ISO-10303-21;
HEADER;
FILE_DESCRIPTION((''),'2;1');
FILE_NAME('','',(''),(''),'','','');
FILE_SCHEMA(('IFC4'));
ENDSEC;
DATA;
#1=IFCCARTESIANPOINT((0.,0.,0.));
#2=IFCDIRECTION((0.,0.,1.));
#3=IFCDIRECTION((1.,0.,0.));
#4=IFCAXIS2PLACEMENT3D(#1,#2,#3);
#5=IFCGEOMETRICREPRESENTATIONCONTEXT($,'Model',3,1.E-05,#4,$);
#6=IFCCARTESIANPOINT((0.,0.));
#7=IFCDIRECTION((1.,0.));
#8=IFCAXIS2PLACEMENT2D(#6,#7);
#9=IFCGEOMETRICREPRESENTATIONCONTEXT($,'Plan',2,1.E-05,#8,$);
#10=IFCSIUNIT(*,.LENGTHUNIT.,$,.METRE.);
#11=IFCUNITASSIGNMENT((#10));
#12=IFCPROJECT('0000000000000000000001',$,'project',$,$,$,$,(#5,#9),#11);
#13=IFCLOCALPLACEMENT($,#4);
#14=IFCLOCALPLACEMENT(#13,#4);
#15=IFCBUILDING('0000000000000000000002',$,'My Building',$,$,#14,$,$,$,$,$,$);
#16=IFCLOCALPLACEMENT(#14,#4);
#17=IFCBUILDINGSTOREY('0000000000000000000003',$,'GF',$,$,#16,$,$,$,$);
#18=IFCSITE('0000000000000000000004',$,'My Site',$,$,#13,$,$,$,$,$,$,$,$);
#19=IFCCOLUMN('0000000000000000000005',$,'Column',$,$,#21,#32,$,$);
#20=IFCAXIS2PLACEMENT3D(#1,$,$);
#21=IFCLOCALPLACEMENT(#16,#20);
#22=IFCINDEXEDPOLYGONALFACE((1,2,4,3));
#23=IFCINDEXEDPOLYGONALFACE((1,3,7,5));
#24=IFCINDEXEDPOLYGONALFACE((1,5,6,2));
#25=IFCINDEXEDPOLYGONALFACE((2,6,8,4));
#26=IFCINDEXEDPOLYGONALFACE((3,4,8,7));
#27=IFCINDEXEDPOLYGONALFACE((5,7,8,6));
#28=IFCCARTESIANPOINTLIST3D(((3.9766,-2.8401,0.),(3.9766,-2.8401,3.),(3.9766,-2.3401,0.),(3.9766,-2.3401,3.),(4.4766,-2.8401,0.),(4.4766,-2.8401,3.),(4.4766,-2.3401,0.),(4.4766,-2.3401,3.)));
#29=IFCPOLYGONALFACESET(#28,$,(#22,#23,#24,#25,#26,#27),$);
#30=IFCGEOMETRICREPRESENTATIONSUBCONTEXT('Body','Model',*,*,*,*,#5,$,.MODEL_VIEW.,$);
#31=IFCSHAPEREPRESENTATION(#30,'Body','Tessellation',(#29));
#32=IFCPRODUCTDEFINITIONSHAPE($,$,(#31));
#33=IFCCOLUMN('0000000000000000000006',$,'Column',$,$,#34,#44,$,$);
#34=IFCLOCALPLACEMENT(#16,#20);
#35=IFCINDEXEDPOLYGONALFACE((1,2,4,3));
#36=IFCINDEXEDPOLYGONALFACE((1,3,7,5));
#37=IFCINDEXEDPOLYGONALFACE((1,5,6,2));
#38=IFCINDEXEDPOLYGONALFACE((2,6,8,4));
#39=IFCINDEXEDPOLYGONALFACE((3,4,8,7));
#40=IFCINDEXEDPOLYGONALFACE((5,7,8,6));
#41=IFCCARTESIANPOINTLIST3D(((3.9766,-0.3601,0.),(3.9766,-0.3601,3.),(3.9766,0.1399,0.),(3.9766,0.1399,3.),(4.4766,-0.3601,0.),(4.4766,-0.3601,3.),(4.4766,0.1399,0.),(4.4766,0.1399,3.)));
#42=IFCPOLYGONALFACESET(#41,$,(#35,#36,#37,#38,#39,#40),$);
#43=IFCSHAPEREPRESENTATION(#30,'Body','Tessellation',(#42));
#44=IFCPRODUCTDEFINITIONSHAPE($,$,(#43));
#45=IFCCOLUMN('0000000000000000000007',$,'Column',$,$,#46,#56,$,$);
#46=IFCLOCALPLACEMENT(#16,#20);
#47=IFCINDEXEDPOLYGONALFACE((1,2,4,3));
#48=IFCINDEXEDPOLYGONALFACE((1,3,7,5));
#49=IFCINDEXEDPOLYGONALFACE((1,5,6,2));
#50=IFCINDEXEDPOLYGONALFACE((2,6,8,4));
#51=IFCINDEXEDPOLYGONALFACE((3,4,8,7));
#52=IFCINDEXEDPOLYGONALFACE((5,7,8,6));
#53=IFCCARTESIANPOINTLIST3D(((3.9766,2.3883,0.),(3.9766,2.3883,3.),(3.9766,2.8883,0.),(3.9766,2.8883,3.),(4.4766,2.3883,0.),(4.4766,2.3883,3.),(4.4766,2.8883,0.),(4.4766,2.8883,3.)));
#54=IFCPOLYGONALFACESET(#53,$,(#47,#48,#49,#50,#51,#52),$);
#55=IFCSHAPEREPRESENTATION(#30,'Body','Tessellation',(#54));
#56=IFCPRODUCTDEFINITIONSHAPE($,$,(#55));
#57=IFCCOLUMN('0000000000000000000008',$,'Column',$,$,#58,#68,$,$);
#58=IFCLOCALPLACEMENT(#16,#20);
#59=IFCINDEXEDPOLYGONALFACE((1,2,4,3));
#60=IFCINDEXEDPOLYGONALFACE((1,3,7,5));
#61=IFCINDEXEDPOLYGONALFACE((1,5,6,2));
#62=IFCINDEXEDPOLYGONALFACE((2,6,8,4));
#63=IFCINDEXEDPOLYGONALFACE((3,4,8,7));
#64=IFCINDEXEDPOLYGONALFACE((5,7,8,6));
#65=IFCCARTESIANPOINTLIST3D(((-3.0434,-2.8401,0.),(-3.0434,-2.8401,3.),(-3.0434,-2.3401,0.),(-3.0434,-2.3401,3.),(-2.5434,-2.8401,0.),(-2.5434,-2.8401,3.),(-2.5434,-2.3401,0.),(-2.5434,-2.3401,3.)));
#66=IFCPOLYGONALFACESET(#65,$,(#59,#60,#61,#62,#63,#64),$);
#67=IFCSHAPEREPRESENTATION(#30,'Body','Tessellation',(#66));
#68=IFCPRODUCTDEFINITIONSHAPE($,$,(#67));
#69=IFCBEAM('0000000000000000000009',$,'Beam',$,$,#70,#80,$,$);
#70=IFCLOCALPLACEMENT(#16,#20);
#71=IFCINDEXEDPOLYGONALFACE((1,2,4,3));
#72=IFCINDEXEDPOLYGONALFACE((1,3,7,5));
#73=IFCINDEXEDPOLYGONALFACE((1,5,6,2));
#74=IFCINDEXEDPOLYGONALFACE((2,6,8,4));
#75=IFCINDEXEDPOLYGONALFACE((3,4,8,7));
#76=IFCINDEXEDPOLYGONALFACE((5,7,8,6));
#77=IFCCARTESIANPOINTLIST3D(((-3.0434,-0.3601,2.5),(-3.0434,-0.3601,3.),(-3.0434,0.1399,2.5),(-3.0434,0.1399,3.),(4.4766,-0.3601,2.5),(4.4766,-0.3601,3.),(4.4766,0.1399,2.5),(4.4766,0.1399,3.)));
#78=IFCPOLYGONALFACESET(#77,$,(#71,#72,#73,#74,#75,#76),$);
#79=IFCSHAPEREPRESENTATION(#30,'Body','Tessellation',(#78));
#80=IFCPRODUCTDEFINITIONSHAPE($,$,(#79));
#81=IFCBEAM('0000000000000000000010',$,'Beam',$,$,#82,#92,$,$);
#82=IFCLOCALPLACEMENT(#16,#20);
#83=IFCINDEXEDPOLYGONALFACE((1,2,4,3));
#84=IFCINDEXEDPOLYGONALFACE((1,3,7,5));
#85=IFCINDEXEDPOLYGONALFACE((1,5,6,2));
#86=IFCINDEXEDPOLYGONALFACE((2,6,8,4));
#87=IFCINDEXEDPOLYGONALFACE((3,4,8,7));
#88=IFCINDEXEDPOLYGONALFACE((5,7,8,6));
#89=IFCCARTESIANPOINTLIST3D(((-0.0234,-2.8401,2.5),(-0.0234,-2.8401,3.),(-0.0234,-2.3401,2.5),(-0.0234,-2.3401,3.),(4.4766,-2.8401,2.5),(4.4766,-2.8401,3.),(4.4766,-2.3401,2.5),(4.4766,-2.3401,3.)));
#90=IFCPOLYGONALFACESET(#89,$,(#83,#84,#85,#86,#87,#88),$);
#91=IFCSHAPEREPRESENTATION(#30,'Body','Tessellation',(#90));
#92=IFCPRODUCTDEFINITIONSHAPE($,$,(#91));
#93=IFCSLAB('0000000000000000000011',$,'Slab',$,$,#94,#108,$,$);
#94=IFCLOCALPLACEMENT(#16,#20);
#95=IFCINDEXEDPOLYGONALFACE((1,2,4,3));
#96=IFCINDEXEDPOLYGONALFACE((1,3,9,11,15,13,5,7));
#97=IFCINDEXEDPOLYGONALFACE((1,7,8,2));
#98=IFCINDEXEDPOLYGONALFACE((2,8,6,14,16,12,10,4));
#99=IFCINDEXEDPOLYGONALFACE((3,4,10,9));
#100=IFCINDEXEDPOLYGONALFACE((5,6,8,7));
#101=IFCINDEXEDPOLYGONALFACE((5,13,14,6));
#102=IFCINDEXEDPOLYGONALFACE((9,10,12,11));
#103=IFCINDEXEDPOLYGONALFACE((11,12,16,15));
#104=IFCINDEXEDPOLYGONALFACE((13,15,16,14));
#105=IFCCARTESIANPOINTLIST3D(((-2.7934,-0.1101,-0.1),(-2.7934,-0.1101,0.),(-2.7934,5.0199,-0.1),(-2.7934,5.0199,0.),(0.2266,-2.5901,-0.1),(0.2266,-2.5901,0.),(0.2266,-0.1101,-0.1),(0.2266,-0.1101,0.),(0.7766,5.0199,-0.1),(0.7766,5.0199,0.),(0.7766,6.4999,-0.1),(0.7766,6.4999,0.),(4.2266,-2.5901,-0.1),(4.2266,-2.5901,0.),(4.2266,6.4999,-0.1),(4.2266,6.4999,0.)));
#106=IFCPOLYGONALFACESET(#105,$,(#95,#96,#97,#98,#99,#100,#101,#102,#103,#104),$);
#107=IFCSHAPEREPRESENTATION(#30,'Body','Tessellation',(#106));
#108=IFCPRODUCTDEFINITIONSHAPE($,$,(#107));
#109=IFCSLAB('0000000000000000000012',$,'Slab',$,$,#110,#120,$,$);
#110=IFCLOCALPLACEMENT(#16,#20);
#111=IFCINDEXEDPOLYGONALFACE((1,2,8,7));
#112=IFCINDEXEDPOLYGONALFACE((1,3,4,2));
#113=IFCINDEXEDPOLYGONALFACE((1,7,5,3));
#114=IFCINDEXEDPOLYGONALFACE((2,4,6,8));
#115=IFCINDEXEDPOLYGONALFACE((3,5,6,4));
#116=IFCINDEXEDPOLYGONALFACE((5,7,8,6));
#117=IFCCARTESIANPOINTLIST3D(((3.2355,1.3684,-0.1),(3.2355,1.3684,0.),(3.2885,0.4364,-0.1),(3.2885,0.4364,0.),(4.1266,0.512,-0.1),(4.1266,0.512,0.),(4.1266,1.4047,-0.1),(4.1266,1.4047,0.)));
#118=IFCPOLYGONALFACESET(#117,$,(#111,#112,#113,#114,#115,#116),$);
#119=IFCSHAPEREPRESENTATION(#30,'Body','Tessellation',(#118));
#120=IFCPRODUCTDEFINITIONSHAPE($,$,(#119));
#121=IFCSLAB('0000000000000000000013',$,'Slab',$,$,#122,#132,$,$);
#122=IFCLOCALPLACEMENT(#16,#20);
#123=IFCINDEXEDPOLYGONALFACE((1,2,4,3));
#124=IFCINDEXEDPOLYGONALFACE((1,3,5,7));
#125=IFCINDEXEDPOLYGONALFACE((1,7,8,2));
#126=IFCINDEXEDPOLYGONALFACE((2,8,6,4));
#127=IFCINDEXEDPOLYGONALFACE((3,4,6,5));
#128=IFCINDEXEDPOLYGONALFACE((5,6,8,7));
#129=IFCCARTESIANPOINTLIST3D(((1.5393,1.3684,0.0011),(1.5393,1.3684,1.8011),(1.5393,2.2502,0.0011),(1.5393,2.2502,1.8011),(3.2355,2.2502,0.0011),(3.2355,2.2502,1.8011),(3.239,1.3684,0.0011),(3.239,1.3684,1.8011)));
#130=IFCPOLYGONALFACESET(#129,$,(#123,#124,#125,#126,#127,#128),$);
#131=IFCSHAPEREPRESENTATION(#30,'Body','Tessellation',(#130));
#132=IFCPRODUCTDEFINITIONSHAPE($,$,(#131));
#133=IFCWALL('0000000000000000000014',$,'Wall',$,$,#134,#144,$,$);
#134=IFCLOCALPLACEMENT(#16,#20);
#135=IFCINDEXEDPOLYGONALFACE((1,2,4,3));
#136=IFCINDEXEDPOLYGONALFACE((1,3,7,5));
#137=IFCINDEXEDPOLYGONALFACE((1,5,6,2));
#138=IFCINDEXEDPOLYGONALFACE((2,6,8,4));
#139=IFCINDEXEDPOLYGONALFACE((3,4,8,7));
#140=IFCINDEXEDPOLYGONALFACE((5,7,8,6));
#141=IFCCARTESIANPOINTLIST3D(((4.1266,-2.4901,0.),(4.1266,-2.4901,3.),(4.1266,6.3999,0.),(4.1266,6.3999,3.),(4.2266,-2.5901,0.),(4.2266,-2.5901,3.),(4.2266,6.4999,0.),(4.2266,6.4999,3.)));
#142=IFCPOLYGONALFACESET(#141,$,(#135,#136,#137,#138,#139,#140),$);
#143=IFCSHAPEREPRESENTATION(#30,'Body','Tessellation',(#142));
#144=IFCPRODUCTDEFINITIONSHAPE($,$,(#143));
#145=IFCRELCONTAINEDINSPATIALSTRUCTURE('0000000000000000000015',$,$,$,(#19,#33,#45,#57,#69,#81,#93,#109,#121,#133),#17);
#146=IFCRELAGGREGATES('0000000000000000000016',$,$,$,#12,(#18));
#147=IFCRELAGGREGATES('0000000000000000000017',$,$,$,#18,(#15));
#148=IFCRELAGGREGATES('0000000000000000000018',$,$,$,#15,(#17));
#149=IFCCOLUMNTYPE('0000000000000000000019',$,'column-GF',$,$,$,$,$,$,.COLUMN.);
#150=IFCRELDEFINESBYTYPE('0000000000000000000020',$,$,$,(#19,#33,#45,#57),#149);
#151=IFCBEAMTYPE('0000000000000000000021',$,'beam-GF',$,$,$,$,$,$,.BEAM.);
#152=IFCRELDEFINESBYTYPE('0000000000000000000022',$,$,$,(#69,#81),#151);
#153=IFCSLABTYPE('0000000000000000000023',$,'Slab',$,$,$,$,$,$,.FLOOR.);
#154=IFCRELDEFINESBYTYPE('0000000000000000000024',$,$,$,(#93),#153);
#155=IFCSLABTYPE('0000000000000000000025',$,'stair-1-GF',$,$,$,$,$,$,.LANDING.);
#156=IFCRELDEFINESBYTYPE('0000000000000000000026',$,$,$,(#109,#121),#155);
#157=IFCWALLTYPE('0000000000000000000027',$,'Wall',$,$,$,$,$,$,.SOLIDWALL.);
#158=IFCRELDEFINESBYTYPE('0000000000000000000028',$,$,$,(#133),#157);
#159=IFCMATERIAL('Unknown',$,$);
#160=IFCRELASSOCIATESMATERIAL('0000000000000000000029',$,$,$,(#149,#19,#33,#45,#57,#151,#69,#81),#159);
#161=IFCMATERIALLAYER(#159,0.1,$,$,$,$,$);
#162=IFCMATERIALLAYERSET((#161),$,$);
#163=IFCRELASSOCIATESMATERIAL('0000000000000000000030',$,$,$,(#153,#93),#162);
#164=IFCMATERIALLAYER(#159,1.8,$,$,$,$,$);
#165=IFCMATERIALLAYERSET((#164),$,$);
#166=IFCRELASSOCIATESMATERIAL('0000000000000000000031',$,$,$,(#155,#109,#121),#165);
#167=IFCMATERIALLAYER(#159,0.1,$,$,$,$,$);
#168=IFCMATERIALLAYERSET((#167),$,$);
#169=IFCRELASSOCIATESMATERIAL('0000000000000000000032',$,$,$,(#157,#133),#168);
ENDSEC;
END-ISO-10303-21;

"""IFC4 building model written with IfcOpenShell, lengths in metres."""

from ifc_helpers import new_model, si_unit, frame, origin_with_axes, origin_2d_with_axis, place, context, subcontext, project, spatial, line, indexed_curve, rectangle, outline, extrude, material, layer, layer_set, layer_usage, material_profile, profile_set, profile_usage, type_object, element, save


model = new_model("IFC4")

# Units and contexts
model_context = context("Model", 3, precision=1e-05, world=origin_with_axes())
plan_context = context("Plan", 2, precision=1e-05, world=origin_2d_with_axis())
body_context_1 = subcontext(model_context, "Body", "Model", "MODEL_VIEW")
ifc_project = project(units=[si_unit("LENGTHUNIT", "METRE")], contexts=[model_context, plan_context])

# Site, building, storey
site_placement = place(None, origin_with_axes())
site = spatial("IfcSite", under=ifc_project, at=site_placement, Name="My Site")
building_placement = place(site_placement, origin_with_axes())
building = spatial("IfcBuilding", under=site, at=building_placement, Name="My Building")
storey_placement = place(building_placement, origin_with_axes())
storey = spatial("IfcBuildingStorey", under=building, at=storey_placement, Name="GF")

# Columns
ifc_material = material(Name="Unknown")
ifc_material_profile_1 = material_profile(ifc_material, rectangle(XDim=0.5, YDim=0.5))
ifc_profile_set_1 = profile_set([ifc_material_profile_1])
ifc_profile_usage_1 = profile_usage(ifc_profile_set_1, cardinal=5)
column_type = type_object("IfcColumnType", Name="column-GF", PredefinedType="COLUMN", material=ifc_profile_set_1)
column_1_placement = place(storey_placement, frame((4.2266, -2.5901, 0.0), z_axis=(0.0, 0.0, 1.0), x_axis=(1.0, 0.0, 0.0)))
element("IfcColumn", 1, at=column_1_placement, inside=storey, type_object=column_type, material=ifc_profile_usage_1, Name="Column", context=body_context_1, shape_type="SweptSolid", body=[
    extrude(rectangle(XDim=0.5, YDim=0.5), origin_with_axes(), (0.0, 0.0, 1.0), 3.0),
])
ifc_profile_usage_2 = profile_usage(ifc_profile_set_1, cardinal=5)
column_2_placement = place(storey_placement, frame((4.2266, -0.1101, 0.0), z_axis=(0.0, 0.0, 1.0), x_axis=(1.0, 0.0, 0.0)))
element("IfcColumn", 2, at=column_2_placement, inside=storey, type_object=column_type, material=ifc_profile_usage_2, Name="Column", context=body_context_1, shape_type="SweptSolid", body=[
    extrude(rectangle(XDim=0.5, YDim=0.5), origin_with_axes(), (0.0, 0.0, 1.0), 3.0),
])
ifc_profile_usage_3 = profile_usage(ifc_profile_set_1, cardinal=5)
column_3_placement = place(storey_placement, frame((4.2266, 2.6383, 0.0), z_axis=(0.0, 0.0, 1.0), x_axis=(1.0, 0.0, 0.0)))
element("IfcColumn", 3, at=column_3_placement, inside=storey, type_object=column_type, material=ifc_profile_usage_3, Name="Column", context=body_context_1, shape_type="SweptSolid", body=[
    extrude(rectangle(XDim=0.5, YDim=0.5), origin_with_axes(), (0.0, 0.0, 1.0), 3.0),
])
ifc_profile_usage_4 = profile_usage(ifc_profile_set_1, cardinal=5)
column_4_placement = place(storey_placement, frame((-2.7934, -2.5901, 0.0), z_axis=(0.0, 0.0, 1.0), x_axis=(1.0, 0.0, 0.0)))
element("IfcColumn", 4, at=column_4_placement, inside=storey, type_object=column_type, material=ifc_profile_usage_4, Name="Column", context=body_context_1, shape_type="SweptSolid", body=[
    extrude(rectangle(XDim=0.5, YDim=0.5), origin_with_axes(), (0.0, 0.0, 1.0), 3.0),
])

# Beams
ifc_material_profile_2 = material_profile(ifc_material, rectangle(XDim=0.5, YDim=0.5))
ifc_profile_set_2 = profile_set([ifc_material_profile_2])
ifc_profile_usage_5 = profile_usage(ifc_profile_set_2, cardinal=7)
beam_type = type_object("IfcBeamType", Name="beam-GF", PredefinedType="BEAM", material=ifc_profile_set_2)
beam_1_placement = place(storey_placement, frame((-3.0434, 0.1399, 3.0), z_axis=(1.0, -0.000001, 0.000001), x_axis=(0.000001, 1.0, 0.0)))
element("IfcBeam", 5, at=beam_1_placement, inside=storey, type_object=beam_type, material=ifc_profile_usage_5, Name="Beam", context=body_context_1, shape_type="SweptSolid", body=[
    extrude(rectangle(XDim=0.5, YDim=0.5), frame((-0.25, -0.25, 0.0), z_axis=(0.0, 0.0, 1.0), x_axis=(1.0, 0.0, 0.0)), (0.0, 0.0, 1.0), 7.52),
])
ifc_profile_usage_6 = profile_usage(ifc_profile_set_2, cardinal=7)
beam_2_placement = place(storey_placement, frame((-0.0234, -2.3401, 3.0), z_axis=(1.0, -0.000001, 0.000001), x_axis=(0.000001, 1.0, 0.0)))
element("IfcBeam", 6, at=beam_2_placement, inside=storey, type_object=beam_type, material=ifc_profile_usage_6, Name="Beam", context=body_context_1, shape_type="SweptSolid", body=[
    extrude(rectangle(XDim=0.5, YDim=0.5), frame((-0.25, -0.25, 0.0), z_axis=(0.0, 0.0, 1.0), x_axis=(1.0, 0.0, 0.0)), (0.0, 0.0, 1.0), 4.5),
])

# Slabs
ifc_layer_1 = layer(ifc_material, 0.1)
ifc_layer_set_1 = layer_set([ifc_layer_1])
ifc_layer_usage_1 = layer_usage(ifc_layer_set_1, "AXIS3", "POSITIVE", -0.1)
slab_type_1 = type_object("IfcSlabType", Name="Slab", PredefinedType="FLOOR", material=ifc_layer_set_1)
slab_1_placement = place(storey_placement, frame((4.2266, -2.5901, 0.0), z_axis=(0.0, 0.0, 1.0), x_axis=(1.0, 0.0, 0.0)))
element("IfcSlab", 7, at=slab_1_placement, inside=storey, type_object=slab_type_1, material=ifc_layer_usage_1, Name="Slab", context=body_context_1, shape_type="SweptSolid", body=[
    extrude(outline(indexed_curve([(0.0, 0.0), (0.0, 9.09), (-3.45, 9.09), (-3.45, 7.61), (-7.02, 7.61), (-7.02, 2.48), (-4.0, 2.48), (-4.0, 0.0), (0.0, 0.0)])), frame((0.0, 0.0, -0.1), z_axis=(0.0, 0.0, 1.0), x_axis=(1.0, 0.0, 0.0)), (0.0, 0.0, 1.0), 0.1),
])
ifc_layer_2 = layer(ifc_material, 1.8)
ifc_layer_set_2 = layer_set([ifc_layer_2])
ifc_layer_usage_2 = layer_usage(ifc_layer_set_2, "AXIS3", "POSITIVE", -0.1)
slab_type_2 = type_object("IfcSlabType", Name="stair-1-GF", PredefinedType="LANDING", material=ifc_layer_set_2)
slab_2_placement = place(storey_placement, frame((4.1266, 0.512, 0.0), z_axis=(0.0, 0.0, 1.0), x_axis=(1.0, 0.0, 0.0)))
element("IfcSlab", 8, at=slab_2_placement, inside=storey, type_object=slab_type_2, material=ifc_layer_usage_2, Name="Slab", context=body_context_1, shape_type="SweptSolid", body=[
    extrude(outline(indexed_curve([(0.0, 0.0), (0.0, 0.8927), (-0.8911, 0.8564), (-0.8381, -0.0756), (0.0, 0.0)])), frame((0.0, 0.0, -0.1), z_axis=(0.0, 0.0, 1.0), x_axis=(1.0, 0.0, 0.0)), (0.0, 0.0, 1.0), 0.1),
])
ifc_layer_usage_3 = layer_usage(ifc_layer_set_2, "AXIS3", "POSITIVE", -1.8)
slab_3_placement = place(storey_placement, frame((3.239, 1.3684, 1.8011), z_axis=(0.0, 0.0, 1.0), x_axis=(1.0, 0.0, 0.0)))
element("IfcSlab", 9, at=slab_3_placement, inside=storey, type_object=slab_type_2, material=ifc_layer_usage_3, Name="Slab", context=body_context_1, shape_type="SweptSolid", body=[
    extrude(outline(indexed_curve([(0.0, 0.0), (-1.6998, 0.0), (-1.6998, 0.8819), (-0.0035, 0.8819), (0.0, 0.0)])), frame((0.0, 0.0, -1.8), z_axis=(0.0, 0.0, 1.0), x_axis=(1.0, 0.0, 0.0)), (0.0, 0.0, 1.0), 1.8),
])

# Shared definitions
ifc_layer_3 = layer(ifc_material, 0.1)
ifc_layer_set_3 = layer_set([ifc_layer_3])
wall_type = type_object("IfcWallType", Name="Wall", PredefinedType="SOLIDWALL", material=ifc_layer_set_3)

# Wall
ifc_layer_usage_4 = layer_usage(ifc_layer_set_3, "AXIS2", "POSITIVE", 0.0)
wall_1_placement = place(storey_placement, frame((4.2266, -2.5901, 0.0), z_axis=(0.0, 0.0, 1.0), x_axis=(0.0, 1.0, 0.0)))
element("IfcWall", 10, at=wall_1_placement, inside=storey, type_object=wall_type, material=ifc_layer_usage_4, Name="Wall", context=body_context_1, shape_type="SweptSolid", body=[
    extrude(outline(indexed_curve([(0.0, 0.0), (0.1, 0.1), (8.99, 0.1), (9.09, 0.0)], segments=[line(1, 2, 3, 4, 1)])), origin_with_axes(), (0.0, 0.0, 1.0), 3.0),
])

save(model, "model.ifc")
